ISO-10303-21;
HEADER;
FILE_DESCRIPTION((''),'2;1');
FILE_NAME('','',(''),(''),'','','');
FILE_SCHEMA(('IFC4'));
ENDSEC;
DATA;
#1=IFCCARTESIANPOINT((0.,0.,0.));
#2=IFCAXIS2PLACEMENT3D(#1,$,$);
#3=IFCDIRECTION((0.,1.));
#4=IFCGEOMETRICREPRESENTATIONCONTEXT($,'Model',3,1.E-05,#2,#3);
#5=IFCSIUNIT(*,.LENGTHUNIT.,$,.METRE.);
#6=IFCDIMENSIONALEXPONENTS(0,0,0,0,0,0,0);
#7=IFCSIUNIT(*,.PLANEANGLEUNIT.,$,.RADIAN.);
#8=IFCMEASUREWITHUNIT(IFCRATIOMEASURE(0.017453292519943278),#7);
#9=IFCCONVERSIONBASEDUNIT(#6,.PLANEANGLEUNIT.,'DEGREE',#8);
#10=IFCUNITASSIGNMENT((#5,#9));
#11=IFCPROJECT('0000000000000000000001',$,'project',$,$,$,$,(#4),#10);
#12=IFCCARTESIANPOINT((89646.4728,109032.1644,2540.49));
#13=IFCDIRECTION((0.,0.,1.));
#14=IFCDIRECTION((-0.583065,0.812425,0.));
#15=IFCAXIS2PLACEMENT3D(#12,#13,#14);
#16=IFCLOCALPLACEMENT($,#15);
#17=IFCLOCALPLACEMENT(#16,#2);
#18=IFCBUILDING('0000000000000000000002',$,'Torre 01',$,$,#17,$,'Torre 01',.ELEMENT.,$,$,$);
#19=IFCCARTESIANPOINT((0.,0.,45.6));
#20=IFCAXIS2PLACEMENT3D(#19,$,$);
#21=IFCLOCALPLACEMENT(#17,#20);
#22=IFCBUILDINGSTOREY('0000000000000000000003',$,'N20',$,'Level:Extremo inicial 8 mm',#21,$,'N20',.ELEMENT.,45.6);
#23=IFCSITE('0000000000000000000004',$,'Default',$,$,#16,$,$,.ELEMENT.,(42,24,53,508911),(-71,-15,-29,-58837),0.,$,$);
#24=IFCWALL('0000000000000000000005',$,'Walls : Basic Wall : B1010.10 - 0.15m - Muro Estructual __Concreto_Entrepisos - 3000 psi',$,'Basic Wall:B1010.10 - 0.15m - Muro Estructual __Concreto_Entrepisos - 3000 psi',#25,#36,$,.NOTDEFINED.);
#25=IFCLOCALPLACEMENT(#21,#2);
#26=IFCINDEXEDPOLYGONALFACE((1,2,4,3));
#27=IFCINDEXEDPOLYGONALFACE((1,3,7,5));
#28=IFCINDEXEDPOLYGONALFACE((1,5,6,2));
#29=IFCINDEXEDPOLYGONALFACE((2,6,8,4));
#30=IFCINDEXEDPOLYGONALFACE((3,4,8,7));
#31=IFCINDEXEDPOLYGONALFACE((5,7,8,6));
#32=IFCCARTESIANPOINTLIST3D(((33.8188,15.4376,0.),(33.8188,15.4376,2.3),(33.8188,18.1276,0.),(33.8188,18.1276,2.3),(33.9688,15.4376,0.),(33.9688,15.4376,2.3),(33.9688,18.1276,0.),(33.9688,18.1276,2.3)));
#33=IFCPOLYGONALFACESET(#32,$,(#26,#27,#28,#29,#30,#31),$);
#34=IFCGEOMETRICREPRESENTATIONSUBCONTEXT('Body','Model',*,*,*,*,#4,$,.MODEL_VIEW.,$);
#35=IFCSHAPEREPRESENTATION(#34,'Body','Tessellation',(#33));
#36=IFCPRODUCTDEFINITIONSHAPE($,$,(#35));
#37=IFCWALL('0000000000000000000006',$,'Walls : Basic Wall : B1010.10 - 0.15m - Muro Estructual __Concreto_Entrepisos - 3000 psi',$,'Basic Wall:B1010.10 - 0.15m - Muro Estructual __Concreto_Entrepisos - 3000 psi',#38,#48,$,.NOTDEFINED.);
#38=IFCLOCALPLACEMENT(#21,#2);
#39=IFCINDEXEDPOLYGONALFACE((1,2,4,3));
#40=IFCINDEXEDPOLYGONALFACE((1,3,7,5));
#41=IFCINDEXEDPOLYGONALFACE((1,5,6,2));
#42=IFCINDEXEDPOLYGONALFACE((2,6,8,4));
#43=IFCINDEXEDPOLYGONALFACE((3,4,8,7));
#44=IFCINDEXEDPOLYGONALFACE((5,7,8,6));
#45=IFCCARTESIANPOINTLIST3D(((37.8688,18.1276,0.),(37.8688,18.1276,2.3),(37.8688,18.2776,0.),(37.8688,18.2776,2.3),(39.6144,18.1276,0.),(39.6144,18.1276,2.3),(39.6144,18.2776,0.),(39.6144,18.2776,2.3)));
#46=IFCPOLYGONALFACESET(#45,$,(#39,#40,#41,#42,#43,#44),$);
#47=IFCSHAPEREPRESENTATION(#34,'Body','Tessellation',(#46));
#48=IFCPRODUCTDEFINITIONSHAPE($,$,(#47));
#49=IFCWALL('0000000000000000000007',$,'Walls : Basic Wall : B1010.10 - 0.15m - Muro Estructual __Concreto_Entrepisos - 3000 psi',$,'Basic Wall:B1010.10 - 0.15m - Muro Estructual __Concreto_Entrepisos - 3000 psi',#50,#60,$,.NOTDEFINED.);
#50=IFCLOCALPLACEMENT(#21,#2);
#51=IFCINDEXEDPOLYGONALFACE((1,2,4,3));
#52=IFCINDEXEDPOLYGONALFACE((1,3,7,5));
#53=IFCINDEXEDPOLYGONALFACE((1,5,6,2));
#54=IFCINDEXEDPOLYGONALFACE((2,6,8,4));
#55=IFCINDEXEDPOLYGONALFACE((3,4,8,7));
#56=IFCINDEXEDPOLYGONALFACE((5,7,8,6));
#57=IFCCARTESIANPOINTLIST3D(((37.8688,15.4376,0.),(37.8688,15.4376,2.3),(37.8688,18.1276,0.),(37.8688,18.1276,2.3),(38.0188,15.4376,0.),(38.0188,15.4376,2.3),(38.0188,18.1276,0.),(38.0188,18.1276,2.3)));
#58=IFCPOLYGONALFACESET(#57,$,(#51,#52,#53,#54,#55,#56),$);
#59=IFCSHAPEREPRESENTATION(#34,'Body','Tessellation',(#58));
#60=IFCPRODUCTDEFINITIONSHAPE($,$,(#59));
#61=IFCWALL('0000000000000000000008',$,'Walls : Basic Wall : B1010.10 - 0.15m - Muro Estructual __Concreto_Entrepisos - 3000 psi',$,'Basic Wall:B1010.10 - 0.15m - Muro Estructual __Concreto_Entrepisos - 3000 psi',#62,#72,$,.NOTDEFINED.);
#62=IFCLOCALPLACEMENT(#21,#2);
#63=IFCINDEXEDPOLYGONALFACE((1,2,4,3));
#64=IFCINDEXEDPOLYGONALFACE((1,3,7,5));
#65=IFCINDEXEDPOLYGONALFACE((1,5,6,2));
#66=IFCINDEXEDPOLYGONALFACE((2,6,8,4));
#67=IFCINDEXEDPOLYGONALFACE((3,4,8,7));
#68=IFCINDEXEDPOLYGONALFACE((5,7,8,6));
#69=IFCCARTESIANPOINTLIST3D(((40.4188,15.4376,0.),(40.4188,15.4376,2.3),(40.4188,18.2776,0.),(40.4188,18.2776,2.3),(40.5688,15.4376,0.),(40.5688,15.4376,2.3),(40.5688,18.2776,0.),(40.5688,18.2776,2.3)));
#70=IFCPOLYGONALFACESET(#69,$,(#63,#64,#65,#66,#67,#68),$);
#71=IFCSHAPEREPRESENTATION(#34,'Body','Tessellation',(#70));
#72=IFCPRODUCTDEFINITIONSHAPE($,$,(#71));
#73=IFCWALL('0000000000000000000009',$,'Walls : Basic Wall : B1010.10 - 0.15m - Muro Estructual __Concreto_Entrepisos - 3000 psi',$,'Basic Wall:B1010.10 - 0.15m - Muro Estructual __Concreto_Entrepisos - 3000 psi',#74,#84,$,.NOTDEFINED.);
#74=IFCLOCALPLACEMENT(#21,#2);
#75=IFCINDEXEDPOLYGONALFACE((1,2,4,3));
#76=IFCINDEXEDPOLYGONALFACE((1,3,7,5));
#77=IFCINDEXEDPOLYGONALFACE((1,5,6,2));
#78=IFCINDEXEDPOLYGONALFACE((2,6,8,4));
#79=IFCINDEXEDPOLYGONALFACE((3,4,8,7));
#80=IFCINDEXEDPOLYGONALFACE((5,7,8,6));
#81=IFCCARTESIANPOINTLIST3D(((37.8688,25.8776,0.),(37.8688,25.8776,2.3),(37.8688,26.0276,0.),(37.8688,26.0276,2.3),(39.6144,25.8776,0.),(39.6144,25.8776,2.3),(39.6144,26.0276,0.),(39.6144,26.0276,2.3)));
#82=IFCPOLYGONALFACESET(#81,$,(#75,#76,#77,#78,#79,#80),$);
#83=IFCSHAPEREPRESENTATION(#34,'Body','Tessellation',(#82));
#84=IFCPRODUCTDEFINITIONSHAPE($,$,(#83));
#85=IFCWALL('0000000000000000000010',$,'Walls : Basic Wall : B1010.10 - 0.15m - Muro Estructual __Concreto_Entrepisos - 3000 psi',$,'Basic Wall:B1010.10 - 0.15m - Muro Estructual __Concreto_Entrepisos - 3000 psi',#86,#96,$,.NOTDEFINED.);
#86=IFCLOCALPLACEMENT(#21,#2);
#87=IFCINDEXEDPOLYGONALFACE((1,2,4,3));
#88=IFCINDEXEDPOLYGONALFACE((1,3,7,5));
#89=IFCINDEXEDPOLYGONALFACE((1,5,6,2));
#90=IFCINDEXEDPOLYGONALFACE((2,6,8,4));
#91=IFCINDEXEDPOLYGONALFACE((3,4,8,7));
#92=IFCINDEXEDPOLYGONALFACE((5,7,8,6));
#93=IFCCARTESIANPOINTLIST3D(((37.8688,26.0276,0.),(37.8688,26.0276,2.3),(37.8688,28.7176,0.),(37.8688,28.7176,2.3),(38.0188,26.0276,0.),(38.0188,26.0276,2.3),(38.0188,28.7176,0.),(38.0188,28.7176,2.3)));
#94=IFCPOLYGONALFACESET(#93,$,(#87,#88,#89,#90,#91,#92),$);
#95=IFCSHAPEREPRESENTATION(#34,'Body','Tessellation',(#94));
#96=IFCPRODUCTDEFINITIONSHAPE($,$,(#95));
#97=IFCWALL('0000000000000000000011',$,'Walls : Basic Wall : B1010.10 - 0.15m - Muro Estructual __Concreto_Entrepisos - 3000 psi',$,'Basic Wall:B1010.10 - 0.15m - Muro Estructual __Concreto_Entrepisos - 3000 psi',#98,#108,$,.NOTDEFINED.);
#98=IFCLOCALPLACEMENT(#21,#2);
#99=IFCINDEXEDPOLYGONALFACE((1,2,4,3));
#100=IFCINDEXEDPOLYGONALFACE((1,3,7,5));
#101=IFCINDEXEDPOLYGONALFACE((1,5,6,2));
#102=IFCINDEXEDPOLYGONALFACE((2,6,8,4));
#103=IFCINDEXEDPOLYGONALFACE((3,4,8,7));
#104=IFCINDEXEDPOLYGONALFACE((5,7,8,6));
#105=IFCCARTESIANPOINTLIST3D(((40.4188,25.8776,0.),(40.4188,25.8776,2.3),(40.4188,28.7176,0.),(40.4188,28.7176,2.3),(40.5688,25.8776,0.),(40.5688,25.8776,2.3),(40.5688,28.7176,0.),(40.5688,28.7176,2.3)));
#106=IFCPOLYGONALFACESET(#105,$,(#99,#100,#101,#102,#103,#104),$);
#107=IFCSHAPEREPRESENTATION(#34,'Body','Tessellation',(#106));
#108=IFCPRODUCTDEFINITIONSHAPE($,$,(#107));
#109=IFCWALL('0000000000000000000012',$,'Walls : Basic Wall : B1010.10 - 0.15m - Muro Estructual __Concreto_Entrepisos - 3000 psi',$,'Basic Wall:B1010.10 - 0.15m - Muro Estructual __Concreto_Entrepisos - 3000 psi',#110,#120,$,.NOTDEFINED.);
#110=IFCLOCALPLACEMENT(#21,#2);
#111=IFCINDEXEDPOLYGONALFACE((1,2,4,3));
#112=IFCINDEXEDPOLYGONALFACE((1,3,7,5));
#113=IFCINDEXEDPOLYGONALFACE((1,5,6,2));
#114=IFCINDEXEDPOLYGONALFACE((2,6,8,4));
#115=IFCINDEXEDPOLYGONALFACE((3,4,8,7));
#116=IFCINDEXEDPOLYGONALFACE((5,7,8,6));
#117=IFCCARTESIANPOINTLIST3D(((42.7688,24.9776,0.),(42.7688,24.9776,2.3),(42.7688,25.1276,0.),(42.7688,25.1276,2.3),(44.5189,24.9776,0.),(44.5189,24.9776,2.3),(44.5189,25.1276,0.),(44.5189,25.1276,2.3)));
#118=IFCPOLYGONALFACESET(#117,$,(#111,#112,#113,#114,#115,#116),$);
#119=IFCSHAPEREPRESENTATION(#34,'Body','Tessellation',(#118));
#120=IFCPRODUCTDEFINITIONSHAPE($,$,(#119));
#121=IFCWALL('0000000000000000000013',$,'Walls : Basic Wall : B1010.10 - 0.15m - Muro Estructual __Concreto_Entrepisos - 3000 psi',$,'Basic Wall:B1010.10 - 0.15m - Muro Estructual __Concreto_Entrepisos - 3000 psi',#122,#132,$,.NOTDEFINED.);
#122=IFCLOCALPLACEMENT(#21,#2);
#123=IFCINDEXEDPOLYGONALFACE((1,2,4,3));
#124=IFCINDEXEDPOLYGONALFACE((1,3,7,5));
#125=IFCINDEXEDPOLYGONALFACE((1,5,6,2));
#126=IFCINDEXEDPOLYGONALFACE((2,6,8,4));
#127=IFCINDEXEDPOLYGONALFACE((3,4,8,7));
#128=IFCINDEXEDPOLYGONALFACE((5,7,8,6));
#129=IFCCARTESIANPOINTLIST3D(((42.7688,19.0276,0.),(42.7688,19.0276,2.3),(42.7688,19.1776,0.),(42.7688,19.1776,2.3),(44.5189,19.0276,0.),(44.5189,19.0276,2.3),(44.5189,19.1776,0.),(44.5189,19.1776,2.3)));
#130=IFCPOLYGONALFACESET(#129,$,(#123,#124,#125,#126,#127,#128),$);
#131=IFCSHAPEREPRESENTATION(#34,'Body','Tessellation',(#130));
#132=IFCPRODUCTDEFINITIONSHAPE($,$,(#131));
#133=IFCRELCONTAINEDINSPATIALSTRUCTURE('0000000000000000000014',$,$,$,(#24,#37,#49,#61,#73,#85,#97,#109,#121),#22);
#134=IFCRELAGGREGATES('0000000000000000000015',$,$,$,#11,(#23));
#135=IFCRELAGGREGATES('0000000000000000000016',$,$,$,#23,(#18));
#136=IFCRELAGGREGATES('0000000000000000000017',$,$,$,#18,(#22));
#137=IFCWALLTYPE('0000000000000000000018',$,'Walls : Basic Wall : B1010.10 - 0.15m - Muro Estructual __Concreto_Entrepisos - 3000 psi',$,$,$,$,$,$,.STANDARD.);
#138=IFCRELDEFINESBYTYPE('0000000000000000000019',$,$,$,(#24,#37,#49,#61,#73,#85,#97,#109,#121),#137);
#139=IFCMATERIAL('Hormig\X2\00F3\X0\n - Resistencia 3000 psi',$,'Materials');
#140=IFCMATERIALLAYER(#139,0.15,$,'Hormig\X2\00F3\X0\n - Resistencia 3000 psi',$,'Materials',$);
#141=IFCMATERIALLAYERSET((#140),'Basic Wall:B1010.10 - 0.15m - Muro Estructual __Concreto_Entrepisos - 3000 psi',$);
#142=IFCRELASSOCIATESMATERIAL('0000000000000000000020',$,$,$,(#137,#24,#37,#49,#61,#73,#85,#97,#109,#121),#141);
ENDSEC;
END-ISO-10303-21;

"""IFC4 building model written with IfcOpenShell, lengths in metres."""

from ifc_helpers import new_model, entity, si_unit, converted_unit, direction, frame, frame_2d, origin, place, context, subcontext, project, spatial, rectangle, extrude, material, layer, layer_set, layer_usage, type_object, element, save


model = new_model("IFC4")

# Units and contexts
model_context = context("Model", 3, precision=1e-05, world=origin(), true_north=direction((0.0, 1.0)))
body_context = subcontext(model_context, "Body", "Model", "MODEL_VIEW")
ifc_project = project(units=[si_unit("LENGTHUNIT", "METRE"), converted_unit("PLANEANGLEUNIT", "DEGREE", entity("IfcRatioMeasure", 0.017453292519943278), si_unit("PLANEANGLEUNIT", "RADIAN"), dimensions=[0, 0, 0, 0, 0, 0, 0])], contexts=[model_context])

# Site, building, storey
site_placement = place(None, frame((89646.4728, 109032.1644, 2540.49), z_axis=(0.0, 0.0, 1.0), x_axis=(-0.583065, 0.812425, 0.0)))
site = spatial("IfcSite", under=ifc_project, at=site_placement, Name="Default", CompositionType="ELEMENT", RefLatitude=(42, 24, 53, 508911), RefLongitude=(-71, -15, -29, -58837), RefElevation=0.0)
building_placement = place(site_placement, origin())
building = spatial("IfcBuilding", under=site, at=building_placement, Name="Torre 01", LongName="Torre 01", CompositionType="ELEMENT")
storey_placement = place(building_placement, frame((0.0, 0.0, 45.6)))
storey = spatial("IfcBuildingStorey", under=building, at=storey_placement, Name="N20", ObjectType="Level:Extremo inicial 8 mm", LongName="N20", CompositionType="ELEMENT", Elevation=45.6)

# Walls
ifc_material = material(Name="Hormigón - Resistencia 3000 psi", Category="Materials")
ifc_layer_1 = layer(ifc_material, 0.15, Name="Hormigón - Resistencia 3000 psi", Category="Materials")
ifc_layer_set_1 = layer_set([ifc_layer_1], Name="Basic Wall:B1010.10 - 0.15m - Muro Estructual __Concreto_Entrepisos - 3000 psi")
wall_type_1 = type_object("IfcWallType", Name="Walls : Basic Wall : B1010.10 - 0.15m - Muro Estructual __Concreto_Entrepisos - 3000 psi", PredefinedType="STANDARD", material=ifc_layer_set_1)
ifc_layer_usage_1 = layer_usage(ifc_layer_set_1, "AXIS2", "NEGATIVE", 0.075)
wall_1_placement = place(storey_placement, frame((33.8938, 18.1276, 0.0), z_axis=(0.0, 0.0, 1.0), x_axis=(0.0, -1.0, 0.0)))
element("IfcWall", 1, at=wall_1_placement, inside=storey, type_object=wall_type_1, material=ifc_layer_usage_1, Name="Walls : Basic Wall : B1010.10 - 0.15m - Muro Estructual __Concreto_Entrepisos - 3000 psi", ObjectType="Basic Wall:B1010.10 - 0.15m - Muro Estructual __Concreto_Entrepisos - 3000 psi", PredefinedType="NOTDEFINED", context=body_context, shape_type="SweptSolid", body=[
    extrude(rectangle(XDim=2.69, YDim=0.15, at=frame_2d((1.345, 0.0), x_axis=(-1.0, 0.0))), origin(), (0.0, 0.0, 1.0), 2.3),
])
ifc_layer_usage_2 = layer_usage(ifc_layer_set_1, "AXIS2", "NEGATIVE", 0.075)
wall_2_placement = place(storey_placement, frame((39.6144, 18.2026, 0.0), z_axis=(0.0, 0.0, 1.0), x_axis=(-1.0, 0.0, 0.0)))
element("IfcWall", 2, at=wall_2_placement, inside=storey, type_object=wall_type_1, material=ifc_layer_usage_2, Name="Walls : Basic Wall : B1010.10 - 0.15m - Muro Estructual __Concreto_Entrepisos - 3000 psi", ObjectType="Basic Wall:B1010.10 - 0.15m - Muro Estructual __Concreto_Entrepisos - 3000 psi", PredefinedType="NOTDEFINED", context=body_context, shape_type="SweptSolid", body=[
    extrude(rectangle(XDim=1.7455, YDim=0.15, at=frame_2d((0.8728, 0.0), x_axis=(-1.0, 0.0))), origin(), (0.0, 0.0, 1.0), 2.3),
])
ifc_layer_usage_3 = layer_usage(ifc_layer_set_1, "AXIS2", "NEGATIVE", 0.075)
wall_3_placement = place(storey_placement, frame((37.9438, 18.1276, 0.0), z_axis=(0.0, 0.0, 1.0), x_axis=(0.0, -1.0, 0.0)))
element("IfcWall", 3, at=wall_3_placement, inside=storey, type_object=wall_type_1, material=ifc_layer_usage_3, Name="Walls : Basic Wall : B1010.10 - 0.15m - Muro Estructual __Concreto_Entrepisos - 3000 psi", ObjectType="Basic Wall:B1010.10 - 0.15m - Muro Estructual __Concreto_Entrepisos - 3000 psi", PredefinedType="NOTDEFINED", context=body_context, shape_type="SweptSolid", body=[
    extrude(rectangle(XDim=2.69, YDim=0.15, at=frame_2d((1.345, 0.0), x_axis=(-1.0, 0.0))), origin(), (0.0, 0.0, 1.0), 2.3),
])
ifc_layer_usage_4 = layer_usage(ifc_layer_set_1, "AXIS2", "NEGATIVE", 0.075)
wall_4_placement = place(storey_placement, frame((40.4938, 18.2776, 0.0), z_axis=(0.0, 0.0, 1.0), x_axis=(0.0, -1.0, 0.0)))
element("IfcWall", 4, at=wall_4_placement, inside=storey, type_object=wall_type_1, material=ifc_layer_usage_4, Name="Walls : Basic Wall : B1010.10 - 0.15m - Muro Estructual __Concreto_Entrepisos - 3000 psi", ObjectType="Basic Wall:B1010.10 - 0.15m - Muro Estructual __Concreto_Entrepisos - 3000 psi", PredefinedType="NOTDEFINED", context=body_context, shape_type="SweptSolid", body=[
    extrude(rectangle(XDim=2.84, YDim=0.15, at=frame_2d((1.42, 0.0), x_axis=(-1.0, 0.0))), origin(), (0.0, 0.0, 1.0), 2.3),
])
ifc_layer_usage_5 = layer_usage(ifc_layer_set_1, "AXIS2", "POSITIVE", -0.075)
wall_5_placement = place(storey_placement, frame((39.6144, 25.9526, 0.0), z_axis=(0.0, 0.0, 1.0), x_axis=(-1.0, 0.0, 0.0)))
element("IfcWall", 5, at=wall_5_placement, inside=storey, type_object=wall_type_1, material=ifc_layer_usage_5, Name="Walls : Basic Wall : B1010.10 - 0.15m - Muro Estructual __Concreto_Entrepisos - 3000 psi", ObjectType="Basic Wall:B1010.10 - 0.15m - Muro Estructual __Concreto_Entrepisos - 3000 psi", PredefinedType="NOTDEFINED", context=body_context, shape_type="SweptSolid", body=[
    extrude(rectangle(XDim=1.7455, YDim=0.15, at=frame_2d((0.8728, 0.0), x_axis=(-1.0, 0.0))), origin(), (0.0, 0.0, 1.0), 2.3),
])
ifc_layer_usage_6 = layer_usage(ifc_layer_set_1, "AXIS2", "POSITIVE", -0.075)
wall_6_placement = place(storey_placement, frame((37.9438, 26.0276, 0.0), z_axis=(0.0, 0.0, 1.0), x_axis=(0.0, 1.0, 0.0)))
element("IfcWall", 6, at=wall_6_placement, inside=storey, type_object=wall_type_1, material=ifc_layer_usage_6, Name="Walls : Basic Wall : B1010.10 - 0.15m - Muro Estructual __Concreto_Entrepisos - 3000 psi", ObjectType="Basic Wall:B1010.10 - 0.15m - Muro Estructual __Concreto_Entrepisos - 3000 psi", PredefinedType="NOTDEFINED", context=body_context, shape_type="SweptSolid", body=[
    extrude(rectangle(XDim=2.69, YDim=0.15, at=frame_2d((1.345, 0.0), x_axis=(-1.0, 0.0))), origin(), (0.0, 0.0, 1.0), 2.3),
])
ifc_layer_usage_7 = layer_usage(ifc_layer_set_1, "AXIS2", "POSITIVE", -0.075)
wall_7_placement = place(storey_placement, frame((40.4938, 25.8776, 0.0), z_axis=(0.0, 0.0, 1.0), x_axis=(0.0, 1.0, 0.0)))
element("IfcWall", 7, at=wall_7_placement, inside=storey, type_object=wall_type_1, material=ifc_layer_usage_7, Name="Walls : Basic Wall : B1010.10 - 0.15m - Muro Estructual __Concreto_Entrepisos - 3000 psi", ObjectType="Basic Wall:B1010.10 - 0.15m - Muro Estructual __Concreto_Entrepisos - 3000 psi", PredefinedType="NOTDEFINED", context=body_context, shape_type="SweptSolid", body=[
    extrude(rectangle(XDim=2.84, YDim=0.15, at=frame_2d((1.42, 0.0), x_axis=(-1.0, 0.0))), origin(), (0.0, 0.0, 1.0), 2.3),
])
ifc_layer_usage_8 = layer_usage(ifc_layer_set_1, "AXIS2", "NEGATIVE", 0.075)
wall_8_placement = place(storey_placement, frame((42.7688, 25.0526, 0.0)))
element("IfcWall", 8, at=wall_8_placement, inside=storey, type_object=wall_type_1, material=ifc_layer_usage_8, Name="Walls : Basic Wall : B1010.10 - 0.15m - Muro Estructual __Concreto_Entrepisos - 3000 psi", ObjectType="Basic Wall:B1010.10 - 0.15m - Muro Estructual __Concreto_Entrepisos - 3000 psi", PredefinedType="NOTDEFINED", context=body_context, shape_type="SweptSolid", body=[
    extrude(rectangle(XDim=1.75, YDim=0.15, at=frame_2d((0.875, 0.0), x_axis=(-1.0, 0.0))), origin(), (0.0, 0.0, 1.0), 2.3),
])
ifc_layer_usage_9 = layer_usage(ifc_layer_set_1, "AXIS2", "POSITIVE", -0.075)
wall_9_placement = place(storey_placement, frame((42.7688, 19.1026, 0.0)))
element("IfcWall", 9, at=wall_9_placement, inside=storey, type_object=wall_type_1, material=ifc_layer_usage_9, Name="Walls : Basic Wall : B1010.10 - 0.15m - Muro Estructual __Concreto_Entrepisos - 3000 psi", ObjectType="Basic Wall:B1010.10 - 0.15m - Muro Estructual __Concreto_Entrepisos - 3000 psi", PredefinedType="NOTDEFINED", context=body_context, shape_type="SweptSolid", body=[
    extrude(rectangle(XDim=1.75, YDim=0.15, at=frame_2d((0.875, 0.0), x_axis=(-1.0, 0.0))), origin(), (0.0, 0.0, 1.0), 2.3),
])

save(model, "model.ifc")
